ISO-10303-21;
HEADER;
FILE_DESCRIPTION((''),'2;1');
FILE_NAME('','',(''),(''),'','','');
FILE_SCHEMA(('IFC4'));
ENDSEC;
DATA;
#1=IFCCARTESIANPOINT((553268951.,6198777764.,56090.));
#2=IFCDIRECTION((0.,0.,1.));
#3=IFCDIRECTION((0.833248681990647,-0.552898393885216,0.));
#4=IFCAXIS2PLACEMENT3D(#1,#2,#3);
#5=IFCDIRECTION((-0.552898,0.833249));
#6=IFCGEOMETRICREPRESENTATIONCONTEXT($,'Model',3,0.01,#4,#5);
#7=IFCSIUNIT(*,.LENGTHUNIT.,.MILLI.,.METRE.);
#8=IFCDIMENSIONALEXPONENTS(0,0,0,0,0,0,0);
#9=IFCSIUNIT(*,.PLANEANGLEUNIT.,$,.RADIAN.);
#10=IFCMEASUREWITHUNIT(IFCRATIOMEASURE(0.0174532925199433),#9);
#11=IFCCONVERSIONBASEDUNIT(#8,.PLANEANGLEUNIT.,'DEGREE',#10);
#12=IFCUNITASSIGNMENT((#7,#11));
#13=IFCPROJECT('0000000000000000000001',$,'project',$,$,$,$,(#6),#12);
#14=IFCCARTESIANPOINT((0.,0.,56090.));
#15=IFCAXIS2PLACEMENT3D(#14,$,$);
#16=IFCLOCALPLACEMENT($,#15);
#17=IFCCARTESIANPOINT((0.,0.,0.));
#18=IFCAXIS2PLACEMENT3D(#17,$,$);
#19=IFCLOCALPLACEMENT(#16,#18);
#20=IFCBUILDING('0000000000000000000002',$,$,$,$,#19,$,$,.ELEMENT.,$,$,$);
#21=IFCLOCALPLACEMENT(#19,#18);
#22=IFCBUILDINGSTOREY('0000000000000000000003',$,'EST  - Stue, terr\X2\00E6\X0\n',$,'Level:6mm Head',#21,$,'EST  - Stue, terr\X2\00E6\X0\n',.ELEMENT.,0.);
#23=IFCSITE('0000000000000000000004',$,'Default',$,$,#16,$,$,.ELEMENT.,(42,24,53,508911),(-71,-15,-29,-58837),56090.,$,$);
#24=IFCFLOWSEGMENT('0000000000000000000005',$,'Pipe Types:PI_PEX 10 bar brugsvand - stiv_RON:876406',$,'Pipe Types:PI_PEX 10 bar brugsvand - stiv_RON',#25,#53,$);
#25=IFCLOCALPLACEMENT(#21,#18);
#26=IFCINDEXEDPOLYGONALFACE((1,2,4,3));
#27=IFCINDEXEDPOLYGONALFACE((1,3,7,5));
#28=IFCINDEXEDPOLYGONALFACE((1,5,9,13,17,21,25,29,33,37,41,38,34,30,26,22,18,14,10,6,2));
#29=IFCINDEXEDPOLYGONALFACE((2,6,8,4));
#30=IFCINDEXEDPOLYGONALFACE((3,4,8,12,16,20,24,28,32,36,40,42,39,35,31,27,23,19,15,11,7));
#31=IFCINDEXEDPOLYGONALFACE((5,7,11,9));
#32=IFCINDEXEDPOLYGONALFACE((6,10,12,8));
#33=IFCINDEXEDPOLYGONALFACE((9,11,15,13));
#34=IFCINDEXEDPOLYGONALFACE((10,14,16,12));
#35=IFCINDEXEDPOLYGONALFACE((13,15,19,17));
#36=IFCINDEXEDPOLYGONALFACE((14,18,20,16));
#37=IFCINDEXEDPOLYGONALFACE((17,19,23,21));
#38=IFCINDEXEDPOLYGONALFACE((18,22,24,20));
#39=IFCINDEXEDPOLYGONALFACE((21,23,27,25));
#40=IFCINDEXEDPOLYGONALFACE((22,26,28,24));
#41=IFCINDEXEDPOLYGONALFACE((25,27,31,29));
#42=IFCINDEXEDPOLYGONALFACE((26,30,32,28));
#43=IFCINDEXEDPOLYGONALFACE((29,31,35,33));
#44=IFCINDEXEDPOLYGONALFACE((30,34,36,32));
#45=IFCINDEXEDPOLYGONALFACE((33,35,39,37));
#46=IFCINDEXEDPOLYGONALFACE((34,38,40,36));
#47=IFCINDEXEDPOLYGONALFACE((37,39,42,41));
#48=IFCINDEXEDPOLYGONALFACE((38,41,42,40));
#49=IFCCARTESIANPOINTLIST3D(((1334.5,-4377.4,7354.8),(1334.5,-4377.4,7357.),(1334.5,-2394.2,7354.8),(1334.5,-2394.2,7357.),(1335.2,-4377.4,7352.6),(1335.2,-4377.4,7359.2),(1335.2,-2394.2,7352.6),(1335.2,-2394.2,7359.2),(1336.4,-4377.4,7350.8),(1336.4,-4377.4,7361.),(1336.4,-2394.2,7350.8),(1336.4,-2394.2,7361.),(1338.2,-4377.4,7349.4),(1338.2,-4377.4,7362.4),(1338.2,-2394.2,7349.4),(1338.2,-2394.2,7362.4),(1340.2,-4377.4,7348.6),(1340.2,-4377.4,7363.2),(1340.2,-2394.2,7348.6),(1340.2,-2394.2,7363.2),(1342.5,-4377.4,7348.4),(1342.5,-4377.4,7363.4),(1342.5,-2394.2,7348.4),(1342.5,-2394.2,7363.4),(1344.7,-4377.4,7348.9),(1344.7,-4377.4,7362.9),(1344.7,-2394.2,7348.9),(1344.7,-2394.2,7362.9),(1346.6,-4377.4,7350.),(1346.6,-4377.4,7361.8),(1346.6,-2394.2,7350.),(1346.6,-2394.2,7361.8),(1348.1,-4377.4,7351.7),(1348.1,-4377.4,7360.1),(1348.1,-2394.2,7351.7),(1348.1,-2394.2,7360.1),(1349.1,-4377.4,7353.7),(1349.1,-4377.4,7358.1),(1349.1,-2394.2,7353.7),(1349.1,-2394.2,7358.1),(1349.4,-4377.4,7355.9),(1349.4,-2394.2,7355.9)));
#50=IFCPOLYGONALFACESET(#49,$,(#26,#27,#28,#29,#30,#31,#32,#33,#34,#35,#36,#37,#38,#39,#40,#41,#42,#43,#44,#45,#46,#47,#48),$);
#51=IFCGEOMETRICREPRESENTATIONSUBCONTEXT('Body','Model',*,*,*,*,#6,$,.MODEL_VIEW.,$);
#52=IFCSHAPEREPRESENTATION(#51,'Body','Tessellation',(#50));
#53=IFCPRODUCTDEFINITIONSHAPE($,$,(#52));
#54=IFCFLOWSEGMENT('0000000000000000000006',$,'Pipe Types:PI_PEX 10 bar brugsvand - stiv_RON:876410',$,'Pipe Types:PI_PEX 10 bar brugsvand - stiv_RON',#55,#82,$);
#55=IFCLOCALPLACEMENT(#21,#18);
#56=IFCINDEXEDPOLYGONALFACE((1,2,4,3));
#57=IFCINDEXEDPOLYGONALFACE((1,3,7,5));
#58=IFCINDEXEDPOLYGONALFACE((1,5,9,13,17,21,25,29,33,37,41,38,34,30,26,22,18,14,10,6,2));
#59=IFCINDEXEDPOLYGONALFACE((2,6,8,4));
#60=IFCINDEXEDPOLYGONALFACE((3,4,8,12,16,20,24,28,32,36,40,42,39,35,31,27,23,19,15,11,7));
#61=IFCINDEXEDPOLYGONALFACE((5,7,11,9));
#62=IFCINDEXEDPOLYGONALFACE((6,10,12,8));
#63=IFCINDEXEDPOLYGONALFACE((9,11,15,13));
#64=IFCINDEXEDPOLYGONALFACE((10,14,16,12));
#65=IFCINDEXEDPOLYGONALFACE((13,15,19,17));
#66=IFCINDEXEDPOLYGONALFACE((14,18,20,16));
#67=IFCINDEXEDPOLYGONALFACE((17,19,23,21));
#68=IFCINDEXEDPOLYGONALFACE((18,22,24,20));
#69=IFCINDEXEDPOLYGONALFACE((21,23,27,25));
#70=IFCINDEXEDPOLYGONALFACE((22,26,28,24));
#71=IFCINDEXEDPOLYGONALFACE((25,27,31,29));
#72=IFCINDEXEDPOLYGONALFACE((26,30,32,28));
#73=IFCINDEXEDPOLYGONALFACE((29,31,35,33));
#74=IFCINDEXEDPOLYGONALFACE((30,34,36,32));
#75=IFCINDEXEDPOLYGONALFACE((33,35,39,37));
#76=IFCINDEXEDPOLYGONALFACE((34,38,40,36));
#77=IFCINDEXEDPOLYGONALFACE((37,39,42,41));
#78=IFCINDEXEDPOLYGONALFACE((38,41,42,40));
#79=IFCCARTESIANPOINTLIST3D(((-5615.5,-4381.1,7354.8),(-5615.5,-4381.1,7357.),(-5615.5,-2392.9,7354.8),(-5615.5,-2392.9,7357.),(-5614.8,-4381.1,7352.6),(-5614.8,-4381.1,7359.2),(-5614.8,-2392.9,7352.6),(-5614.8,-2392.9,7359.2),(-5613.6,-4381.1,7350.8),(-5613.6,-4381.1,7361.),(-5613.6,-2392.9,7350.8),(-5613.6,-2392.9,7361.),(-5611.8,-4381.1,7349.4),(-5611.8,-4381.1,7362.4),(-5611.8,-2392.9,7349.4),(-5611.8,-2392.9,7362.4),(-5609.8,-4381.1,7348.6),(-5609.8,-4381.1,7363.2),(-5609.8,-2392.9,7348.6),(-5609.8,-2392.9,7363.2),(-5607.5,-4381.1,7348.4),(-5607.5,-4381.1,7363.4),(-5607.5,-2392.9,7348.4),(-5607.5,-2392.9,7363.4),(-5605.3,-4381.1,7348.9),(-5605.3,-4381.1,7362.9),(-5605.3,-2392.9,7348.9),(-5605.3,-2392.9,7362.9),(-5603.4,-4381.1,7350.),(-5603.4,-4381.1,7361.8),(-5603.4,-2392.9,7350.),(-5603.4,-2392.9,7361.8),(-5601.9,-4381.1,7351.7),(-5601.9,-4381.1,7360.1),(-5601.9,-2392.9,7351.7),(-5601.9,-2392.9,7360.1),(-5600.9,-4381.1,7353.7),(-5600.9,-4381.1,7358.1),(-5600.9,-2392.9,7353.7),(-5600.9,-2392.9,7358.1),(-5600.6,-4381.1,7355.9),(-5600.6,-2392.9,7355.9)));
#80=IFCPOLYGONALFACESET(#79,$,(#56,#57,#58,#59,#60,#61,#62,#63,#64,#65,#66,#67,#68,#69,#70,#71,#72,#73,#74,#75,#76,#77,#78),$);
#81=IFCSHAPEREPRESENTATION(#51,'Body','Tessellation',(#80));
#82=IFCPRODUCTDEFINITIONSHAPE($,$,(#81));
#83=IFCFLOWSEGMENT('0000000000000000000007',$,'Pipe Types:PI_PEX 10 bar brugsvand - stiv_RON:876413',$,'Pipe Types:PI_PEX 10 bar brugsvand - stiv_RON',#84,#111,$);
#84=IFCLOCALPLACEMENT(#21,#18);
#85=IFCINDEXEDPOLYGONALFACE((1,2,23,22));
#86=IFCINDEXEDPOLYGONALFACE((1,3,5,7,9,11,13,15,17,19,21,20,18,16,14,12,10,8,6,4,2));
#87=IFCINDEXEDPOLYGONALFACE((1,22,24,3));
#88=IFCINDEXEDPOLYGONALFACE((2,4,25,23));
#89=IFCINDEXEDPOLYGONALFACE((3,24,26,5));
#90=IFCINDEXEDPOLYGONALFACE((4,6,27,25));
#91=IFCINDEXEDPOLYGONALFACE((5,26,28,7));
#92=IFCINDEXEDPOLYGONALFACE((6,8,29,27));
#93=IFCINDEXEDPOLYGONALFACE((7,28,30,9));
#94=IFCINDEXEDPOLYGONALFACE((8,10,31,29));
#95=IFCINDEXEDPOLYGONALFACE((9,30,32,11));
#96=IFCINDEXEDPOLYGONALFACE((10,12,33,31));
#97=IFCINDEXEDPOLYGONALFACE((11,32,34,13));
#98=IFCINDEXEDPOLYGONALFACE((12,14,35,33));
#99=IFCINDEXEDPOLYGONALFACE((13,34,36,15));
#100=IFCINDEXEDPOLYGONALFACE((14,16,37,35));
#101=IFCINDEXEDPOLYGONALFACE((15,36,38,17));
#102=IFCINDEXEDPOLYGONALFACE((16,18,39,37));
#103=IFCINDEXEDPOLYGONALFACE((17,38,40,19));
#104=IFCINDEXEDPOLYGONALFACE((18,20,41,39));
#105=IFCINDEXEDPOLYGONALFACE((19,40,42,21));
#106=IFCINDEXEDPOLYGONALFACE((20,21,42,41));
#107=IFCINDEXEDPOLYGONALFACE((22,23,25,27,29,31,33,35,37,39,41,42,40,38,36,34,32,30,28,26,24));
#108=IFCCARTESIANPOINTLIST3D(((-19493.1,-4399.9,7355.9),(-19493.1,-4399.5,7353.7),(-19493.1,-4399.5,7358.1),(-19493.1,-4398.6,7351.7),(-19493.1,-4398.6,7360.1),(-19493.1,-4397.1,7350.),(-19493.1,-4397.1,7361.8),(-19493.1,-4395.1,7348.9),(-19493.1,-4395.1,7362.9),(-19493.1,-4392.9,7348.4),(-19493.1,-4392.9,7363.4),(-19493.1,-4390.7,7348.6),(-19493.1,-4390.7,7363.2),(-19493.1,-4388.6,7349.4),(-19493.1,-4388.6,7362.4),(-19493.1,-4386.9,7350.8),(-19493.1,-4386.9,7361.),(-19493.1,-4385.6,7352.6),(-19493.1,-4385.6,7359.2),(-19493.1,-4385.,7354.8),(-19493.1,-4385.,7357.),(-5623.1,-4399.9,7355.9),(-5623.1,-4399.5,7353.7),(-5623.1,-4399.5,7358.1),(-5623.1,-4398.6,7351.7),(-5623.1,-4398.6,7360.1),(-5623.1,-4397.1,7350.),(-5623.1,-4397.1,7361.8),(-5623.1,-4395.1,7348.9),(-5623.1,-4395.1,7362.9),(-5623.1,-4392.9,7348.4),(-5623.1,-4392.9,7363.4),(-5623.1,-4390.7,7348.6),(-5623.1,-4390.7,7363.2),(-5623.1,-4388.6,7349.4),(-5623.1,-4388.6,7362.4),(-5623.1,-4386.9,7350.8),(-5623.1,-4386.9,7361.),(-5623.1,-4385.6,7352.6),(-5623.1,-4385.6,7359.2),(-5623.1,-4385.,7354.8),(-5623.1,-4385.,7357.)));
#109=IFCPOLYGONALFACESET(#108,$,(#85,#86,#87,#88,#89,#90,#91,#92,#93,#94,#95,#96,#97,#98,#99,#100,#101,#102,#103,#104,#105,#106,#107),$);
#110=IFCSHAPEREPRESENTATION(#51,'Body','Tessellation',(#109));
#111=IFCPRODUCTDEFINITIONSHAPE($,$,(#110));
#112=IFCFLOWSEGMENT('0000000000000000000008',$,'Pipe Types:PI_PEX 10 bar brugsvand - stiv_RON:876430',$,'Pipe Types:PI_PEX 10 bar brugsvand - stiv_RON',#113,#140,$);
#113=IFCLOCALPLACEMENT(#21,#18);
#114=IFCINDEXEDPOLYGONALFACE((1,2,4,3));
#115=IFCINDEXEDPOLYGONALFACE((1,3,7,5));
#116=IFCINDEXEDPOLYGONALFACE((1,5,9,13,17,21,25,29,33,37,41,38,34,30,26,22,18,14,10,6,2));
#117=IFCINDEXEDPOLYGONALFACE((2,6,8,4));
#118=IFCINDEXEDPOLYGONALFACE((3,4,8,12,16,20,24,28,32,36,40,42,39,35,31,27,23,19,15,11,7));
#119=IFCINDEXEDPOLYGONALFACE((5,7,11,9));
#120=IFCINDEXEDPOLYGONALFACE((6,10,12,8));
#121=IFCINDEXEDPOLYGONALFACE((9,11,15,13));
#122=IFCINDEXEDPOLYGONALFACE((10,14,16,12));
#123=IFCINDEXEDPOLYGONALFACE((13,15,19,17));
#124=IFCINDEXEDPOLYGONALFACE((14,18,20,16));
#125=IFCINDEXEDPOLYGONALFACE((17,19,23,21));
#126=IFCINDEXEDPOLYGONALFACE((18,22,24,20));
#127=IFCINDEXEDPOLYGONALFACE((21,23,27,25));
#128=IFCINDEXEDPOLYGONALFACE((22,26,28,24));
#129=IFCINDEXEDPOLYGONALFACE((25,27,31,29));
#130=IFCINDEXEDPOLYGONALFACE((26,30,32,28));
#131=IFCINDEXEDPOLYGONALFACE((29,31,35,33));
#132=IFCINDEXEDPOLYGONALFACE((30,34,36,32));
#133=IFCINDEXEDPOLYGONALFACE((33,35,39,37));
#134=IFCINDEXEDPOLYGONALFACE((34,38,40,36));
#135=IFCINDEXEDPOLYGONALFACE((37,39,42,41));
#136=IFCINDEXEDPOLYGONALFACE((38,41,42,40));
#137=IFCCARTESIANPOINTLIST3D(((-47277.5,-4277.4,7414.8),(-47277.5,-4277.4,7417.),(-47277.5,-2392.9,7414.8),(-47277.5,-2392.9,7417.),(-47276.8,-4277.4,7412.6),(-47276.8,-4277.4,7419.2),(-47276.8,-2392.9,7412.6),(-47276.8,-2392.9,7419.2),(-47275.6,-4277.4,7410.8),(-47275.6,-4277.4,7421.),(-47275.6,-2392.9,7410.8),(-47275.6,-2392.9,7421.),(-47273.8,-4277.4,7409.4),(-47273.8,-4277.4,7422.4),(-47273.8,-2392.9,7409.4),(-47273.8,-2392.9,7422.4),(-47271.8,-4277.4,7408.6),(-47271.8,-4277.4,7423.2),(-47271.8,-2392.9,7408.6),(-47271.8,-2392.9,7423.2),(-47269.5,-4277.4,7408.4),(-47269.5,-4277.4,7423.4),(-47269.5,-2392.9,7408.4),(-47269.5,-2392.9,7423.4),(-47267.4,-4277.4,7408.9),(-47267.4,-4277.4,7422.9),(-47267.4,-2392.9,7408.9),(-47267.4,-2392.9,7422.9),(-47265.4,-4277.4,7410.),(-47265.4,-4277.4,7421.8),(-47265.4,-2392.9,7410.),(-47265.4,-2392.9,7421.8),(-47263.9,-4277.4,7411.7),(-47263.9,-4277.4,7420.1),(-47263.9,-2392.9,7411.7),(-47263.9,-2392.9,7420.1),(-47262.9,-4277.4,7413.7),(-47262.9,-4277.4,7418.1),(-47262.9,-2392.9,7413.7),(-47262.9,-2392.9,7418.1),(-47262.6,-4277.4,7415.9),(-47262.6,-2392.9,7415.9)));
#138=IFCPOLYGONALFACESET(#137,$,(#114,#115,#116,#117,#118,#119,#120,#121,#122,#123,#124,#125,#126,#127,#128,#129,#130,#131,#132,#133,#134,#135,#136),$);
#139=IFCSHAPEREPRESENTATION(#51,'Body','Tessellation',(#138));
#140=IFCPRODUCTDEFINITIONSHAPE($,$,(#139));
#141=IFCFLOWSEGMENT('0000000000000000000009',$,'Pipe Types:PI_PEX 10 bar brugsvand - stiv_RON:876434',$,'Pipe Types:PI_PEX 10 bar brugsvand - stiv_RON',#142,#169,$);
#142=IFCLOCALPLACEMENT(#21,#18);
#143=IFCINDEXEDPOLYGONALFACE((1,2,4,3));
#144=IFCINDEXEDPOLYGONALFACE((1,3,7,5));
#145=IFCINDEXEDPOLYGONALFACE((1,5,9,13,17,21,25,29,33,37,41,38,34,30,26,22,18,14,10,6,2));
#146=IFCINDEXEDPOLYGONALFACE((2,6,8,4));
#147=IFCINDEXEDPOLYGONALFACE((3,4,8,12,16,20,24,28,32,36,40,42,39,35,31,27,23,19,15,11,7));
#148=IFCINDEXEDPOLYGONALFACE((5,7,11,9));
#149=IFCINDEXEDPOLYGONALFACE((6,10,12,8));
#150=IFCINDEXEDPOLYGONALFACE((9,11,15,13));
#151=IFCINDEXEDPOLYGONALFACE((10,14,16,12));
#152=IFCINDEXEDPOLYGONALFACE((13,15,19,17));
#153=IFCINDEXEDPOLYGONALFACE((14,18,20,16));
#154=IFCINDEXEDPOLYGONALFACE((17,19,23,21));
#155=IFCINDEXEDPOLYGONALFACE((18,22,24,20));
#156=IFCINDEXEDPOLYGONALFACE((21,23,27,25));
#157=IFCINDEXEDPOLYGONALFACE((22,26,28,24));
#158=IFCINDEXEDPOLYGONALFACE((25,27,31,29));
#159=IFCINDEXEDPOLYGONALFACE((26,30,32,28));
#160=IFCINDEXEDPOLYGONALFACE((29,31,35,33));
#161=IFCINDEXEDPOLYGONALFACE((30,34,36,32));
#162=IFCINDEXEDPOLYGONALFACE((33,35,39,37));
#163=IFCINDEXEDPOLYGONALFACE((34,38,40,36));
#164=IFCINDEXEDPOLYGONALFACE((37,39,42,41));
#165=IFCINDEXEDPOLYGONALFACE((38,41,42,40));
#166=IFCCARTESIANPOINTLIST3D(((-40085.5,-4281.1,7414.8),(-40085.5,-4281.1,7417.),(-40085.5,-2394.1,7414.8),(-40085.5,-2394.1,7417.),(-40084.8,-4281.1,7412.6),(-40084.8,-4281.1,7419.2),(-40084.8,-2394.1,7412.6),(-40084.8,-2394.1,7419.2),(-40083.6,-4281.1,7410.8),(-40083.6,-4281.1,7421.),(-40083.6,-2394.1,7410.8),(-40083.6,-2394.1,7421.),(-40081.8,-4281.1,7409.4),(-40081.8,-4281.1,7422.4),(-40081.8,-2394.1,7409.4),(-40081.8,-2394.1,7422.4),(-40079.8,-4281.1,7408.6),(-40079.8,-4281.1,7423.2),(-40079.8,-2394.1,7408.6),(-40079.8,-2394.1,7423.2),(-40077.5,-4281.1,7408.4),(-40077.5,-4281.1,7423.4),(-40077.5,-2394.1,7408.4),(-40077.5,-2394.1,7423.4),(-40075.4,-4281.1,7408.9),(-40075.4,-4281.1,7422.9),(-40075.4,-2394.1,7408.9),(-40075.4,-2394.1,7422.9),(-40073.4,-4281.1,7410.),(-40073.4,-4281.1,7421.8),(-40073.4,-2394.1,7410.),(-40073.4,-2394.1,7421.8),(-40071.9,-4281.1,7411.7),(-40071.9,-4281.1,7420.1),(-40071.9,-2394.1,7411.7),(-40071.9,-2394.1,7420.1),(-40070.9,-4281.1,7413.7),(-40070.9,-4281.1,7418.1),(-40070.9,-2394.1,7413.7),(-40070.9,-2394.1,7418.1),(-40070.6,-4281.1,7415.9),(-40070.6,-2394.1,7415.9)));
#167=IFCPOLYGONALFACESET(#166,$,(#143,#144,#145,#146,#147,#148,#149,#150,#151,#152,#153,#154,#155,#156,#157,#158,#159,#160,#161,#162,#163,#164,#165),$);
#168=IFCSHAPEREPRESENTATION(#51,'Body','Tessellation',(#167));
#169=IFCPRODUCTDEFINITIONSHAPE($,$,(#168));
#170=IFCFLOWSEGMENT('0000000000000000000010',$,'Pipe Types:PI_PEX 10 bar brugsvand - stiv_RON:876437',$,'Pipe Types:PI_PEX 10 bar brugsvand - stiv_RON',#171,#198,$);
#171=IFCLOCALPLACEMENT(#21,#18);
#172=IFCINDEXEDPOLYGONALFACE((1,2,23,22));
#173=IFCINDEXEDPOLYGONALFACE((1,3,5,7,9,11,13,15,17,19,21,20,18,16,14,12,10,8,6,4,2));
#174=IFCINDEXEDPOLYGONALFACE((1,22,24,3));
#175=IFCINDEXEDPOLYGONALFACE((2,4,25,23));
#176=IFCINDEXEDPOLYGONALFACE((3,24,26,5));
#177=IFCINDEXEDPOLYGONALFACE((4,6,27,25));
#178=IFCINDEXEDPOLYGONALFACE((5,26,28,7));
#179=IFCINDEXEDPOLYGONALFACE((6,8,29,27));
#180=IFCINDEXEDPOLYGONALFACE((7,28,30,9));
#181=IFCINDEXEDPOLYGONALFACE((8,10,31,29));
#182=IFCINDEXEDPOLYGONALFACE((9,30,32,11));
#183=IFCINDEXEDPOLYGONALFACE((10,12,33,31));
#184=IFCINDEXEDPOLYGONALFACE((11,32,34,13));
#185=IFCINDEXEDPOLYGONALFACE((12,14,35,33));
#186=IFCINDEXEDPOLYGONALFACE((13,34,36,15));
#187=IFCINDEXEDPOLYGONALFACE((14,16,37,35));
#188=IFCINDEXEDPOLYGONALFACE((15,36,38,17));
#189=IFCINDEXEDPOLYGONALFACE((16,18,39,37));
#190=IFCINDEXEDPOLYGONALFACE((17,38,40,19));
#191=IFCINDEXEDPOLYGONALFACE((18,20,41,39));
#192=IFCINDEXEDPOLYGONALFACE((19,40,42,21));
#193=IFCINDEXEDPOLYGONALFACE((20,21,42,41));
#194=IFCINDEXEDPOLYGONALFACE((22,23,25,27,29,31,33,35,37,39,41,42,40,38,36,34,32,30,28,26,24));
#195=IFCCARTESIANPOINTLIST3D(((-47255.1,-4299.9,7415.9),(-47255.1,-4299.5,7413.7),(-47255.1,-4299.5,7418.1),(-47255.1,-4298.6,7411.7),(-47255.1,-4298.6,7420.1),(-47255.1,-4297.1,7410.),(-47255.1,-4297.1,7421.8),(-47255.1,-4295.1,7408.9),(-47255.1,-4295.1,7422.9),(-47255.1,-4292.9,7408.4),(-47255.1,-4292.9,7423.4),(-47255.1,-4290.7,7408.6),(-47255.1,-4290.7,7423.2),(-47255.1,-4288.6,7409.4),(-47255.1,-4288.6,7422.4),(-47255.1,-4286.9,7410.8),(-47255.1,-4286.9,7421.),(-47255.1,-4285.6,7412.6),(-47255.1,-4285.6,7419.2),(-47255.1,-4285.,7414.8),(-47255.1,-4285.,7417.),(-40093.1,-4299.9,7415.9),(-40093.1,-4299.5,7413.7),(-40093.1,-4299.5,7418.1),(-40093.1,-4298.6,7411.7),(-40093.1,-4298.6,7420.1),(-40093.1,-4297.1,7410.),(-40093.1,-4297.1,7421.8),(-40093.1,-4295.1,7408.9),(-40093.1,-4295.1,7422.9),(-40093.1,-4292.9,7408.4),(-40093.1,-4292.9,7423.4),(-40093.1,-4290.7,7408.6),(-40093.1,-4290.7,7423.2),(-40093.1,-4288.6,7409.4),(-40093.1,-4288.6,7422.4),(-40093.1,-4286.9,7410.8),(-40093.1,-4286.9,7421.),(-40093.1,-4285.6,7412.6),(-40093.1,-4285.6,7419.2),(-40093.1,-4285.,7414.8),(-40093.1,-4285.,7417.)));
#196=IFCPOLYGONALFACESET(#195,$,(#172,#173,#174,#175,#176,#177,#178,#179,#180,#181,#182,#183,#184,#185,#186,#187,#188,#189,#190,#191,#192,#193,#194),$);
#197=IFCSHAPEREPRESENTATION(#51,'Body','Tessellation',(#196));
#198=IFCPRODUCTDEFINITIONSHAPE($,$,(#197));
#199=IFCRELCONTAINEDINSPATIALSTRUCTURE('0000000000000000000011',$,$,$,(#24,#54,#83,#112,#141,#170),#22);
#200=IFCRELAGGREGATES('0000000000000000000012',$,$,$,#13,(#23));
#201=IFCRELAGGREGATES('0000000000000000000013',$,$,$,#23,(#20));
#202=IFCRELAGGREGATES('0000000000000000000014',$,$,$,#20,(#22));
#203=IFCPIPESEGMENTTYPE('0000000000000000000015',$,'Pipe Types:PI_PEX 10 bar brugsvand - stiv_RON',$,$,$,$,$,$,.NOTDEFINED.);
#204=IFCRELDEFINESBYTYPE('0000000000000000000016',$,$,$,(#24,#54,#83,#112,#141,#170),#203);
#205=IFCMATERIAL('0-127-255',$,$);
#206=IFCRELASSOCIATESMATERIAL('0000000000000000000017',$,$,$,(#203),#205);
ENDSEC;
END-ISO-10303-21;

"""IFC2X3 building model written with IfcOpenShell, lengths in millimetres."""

from ifc_helpers import new_model, entity, si_unit, converted_unit, direction, frame, origin, origin_2d_with_axis, place, context, subcontext, project, spatial, circle, extrude, material, type_object, element, save


model = new_model("IFC2X3")

# Units and contexts
model_context = context("Model", 3, precision=0.01, world=frame((553268951.0, 6198777764.0, 56090.0), z_axis=(0.0, 0.0, 1.0), x_axis=(0.833248681990647, -0.552898393885216, 0.0)), true_north=direction((-0.552898, 0.833249)))
body_context = subcontext(model_context, "Body", "Model", "MODEL_VIEW")
ifc_project = project(units=[si_unit("LENGTHUNIT", "METRE", prefix="MILLI"), converted_unit("PLANEANGLEUNIT", "DEGREE", entity("IfcRatioMeasure", 0.0174532925199433), si_unit("PLANEANGLEUNIT", "RADIAN"), dimensions=[0, 0, 0, 0, 0, 0, 0])], contexts=[model_context])

# Site, building, storey
site_placement = place(None, frame((0.0, 0.0, 56090.0)))
site = spatial("IfcSite", under=ifc_project, at=site_placement, Name="Default", CompositionType="ELEMENT", RefLatitude=(42, 24, 53, 508911), RefLongitude=(-71, -15, -29, -58837), RefElevation=56090.0)
building_placement = place(site_placement, origin())
building = spatial("IfcBuilding", under=site, at=building_placement, CompositionType="ELEMENT")
storey_placement = place(building_placement, frame((0.0, 0.0, 0.0)))
storey = spatial("IfcBuildingStorey", under=building, at=storey_placement, Name="EST  - Stue, terræn", ObjectType="Level:6mm Head", LongName="EST  - Stue, terræn", CompositionType="ELEMENT", Elevation=0.0)

# Flow segments
ifc_material_1 = material(Name="0-127-255")
pipe_segment_type_1 = type_object("IfcPipeSegmentType", Name="Pipe Types:PI_PEX 10 bar brugsvand - stiv_RON", PredefinedType="NOTDEFINED", material=ifc_material_1)
flow_segment_1_placement = place(storey_placement, origin())
element("IfcFlowSegment", 1, at=flow_segment_1_placement, inside=storey, type_object=pipe_segment_type_1, Name="Pipe Types:PI_PEX 10 bar brugsvand - stiv_RON:876406", ObjectType="Pipe Types:PI_PEX 10 bar brugsvand - stiv_RON", context=body_context, shape_type="SweptSolid", body=[
    extrude(circle(Radius=7.5, at=origin_2d_with_axis()), frame((1341.9, -4377.4, 7355.9), z_axis=(0.0, 1.0, 0.0), x_axis=(1.0, 0.0, 0.0)), (0.0, 0.0, 1.0), 1983.2),
])
flow_segment_2_placement = place(storey_placement, origin())
element("IfcFlowSegment", 2, at=flow_segment_2_placement, inside=storey, type_object=pipe_segment_type_1, Name="Pipe Types:PI_PEX 10 bar brugsvand - stiv_RON:876410", ObjectType="Pipe Types:PI_PEX 10 bar brugsvand - stiv_RON", context=body_context, shape_type="SweptSolid", body=[
    extrude(circle(Radius=7.5, at=origin_2d_with_axis()), frame((-5608.1, -4381.1, 7355.9), z_axis=(0.0, 1.0, 0.0), x_axis=(1.0, 0.0, 0.0)), (0.0, 0.0, 1.0), 1988.3),
])
flow_segment_3_placement = place(storey_placement, origin())
element("IfcFlowSegment", 3, at=flow_segment_3_placement, inside=storey, type_object=pipe_segment_type_1, Name="Pipe Types:PI_PEX 10 bar brugsvand - stiv_RON:876413", ObjectType="Pipe Types:PI_PEX 10 bar brugsvand - stiv_RON", context=body_context, shape_type="SweptSolid", body=[
    extrude(circle(Radius=7.5, at=origin_2d_with_axis()), frame((-19493.1, -4392.4, 7355.9), z_axis=(1.0, 0.0, 0.0), x_axis=(0.0, -1.0, 0.0)), (0.0, 0.0, 1.0), 13870.0),
])
flow_segment_4_placement = place(storey_placement, origin())
element("IfcFlowSegment", 4, at=flow_segment_4_placement, inside=storey, type_object=pipe_segment_type_1, Name="Pipe Types:PI_PEX 10 bar brugsvand - stiv_RON:876430", ObjectType="Pipe Types:PI_PEX 10 bar brugsvand - stiv_RON", context=body_context, shape_type="SweptSolid", body=[
    extrude(circle(Radius=7.5, at=origin_2d_with_axis()), frame((-47270.1, -4277.4, 7415.9), z_axis=(0.0, 1.0, 0.0), x_axis=(1.0, 0.0, 0.0)), (0.0, 0.0, 1.0), 1884.5),
])
flow_segment_5_placement = place(storey_placement, origin())
element("IfcFlowSegment", 5, at=flow_segment_5_placement, inside=storey, type_object=pipe_segment_type_1, Name="Pipe Types:PI_PEX 10 bar brugsvand - stiv_RON:876434", ObjectType="Pipe Types:PI_PEX 10 bar brugsvand - stiv_RON", context=body_context, shape_type="SweptSolid", body=[
    extrude(circle(Radius=7.5, at=origin_2d_with_axis()), frame((-40078.1, -4281.1, 7415.9), z_axis=(0.0, 1.0, 0.0), x_axis=(1.0, 0.0, 0.0)), (0.0, 0.0, 1.0), 1887.0),
])
flow_segment_6_placement = place(storey_placement, origin())
element("IfcFlowSegment", 6, at=flow_segment_6_placement, inside=storey, type_object=pipe_segment_type_1, Name="Pipe Types:PI_PEX 10 bar brugsvand - stiv_RON:876437", ObjectType="Pipe Types:PI_PEX 10 bar brugsvand - stiv_RON", context=body_context, shape_type="SweptSolid", body=[
    extrude(circle(Radius=7.5, at=origin_2d_with_axis()), frame((-47255.1, -4292.4, 7415.9), z_axis=(1.0, 0.0, 0.0), x_axis=(0.0, -1.0, 0.0)), (0.0, 0.0, 1.0), 7162.0),
])

save(model, "model.ifc")
